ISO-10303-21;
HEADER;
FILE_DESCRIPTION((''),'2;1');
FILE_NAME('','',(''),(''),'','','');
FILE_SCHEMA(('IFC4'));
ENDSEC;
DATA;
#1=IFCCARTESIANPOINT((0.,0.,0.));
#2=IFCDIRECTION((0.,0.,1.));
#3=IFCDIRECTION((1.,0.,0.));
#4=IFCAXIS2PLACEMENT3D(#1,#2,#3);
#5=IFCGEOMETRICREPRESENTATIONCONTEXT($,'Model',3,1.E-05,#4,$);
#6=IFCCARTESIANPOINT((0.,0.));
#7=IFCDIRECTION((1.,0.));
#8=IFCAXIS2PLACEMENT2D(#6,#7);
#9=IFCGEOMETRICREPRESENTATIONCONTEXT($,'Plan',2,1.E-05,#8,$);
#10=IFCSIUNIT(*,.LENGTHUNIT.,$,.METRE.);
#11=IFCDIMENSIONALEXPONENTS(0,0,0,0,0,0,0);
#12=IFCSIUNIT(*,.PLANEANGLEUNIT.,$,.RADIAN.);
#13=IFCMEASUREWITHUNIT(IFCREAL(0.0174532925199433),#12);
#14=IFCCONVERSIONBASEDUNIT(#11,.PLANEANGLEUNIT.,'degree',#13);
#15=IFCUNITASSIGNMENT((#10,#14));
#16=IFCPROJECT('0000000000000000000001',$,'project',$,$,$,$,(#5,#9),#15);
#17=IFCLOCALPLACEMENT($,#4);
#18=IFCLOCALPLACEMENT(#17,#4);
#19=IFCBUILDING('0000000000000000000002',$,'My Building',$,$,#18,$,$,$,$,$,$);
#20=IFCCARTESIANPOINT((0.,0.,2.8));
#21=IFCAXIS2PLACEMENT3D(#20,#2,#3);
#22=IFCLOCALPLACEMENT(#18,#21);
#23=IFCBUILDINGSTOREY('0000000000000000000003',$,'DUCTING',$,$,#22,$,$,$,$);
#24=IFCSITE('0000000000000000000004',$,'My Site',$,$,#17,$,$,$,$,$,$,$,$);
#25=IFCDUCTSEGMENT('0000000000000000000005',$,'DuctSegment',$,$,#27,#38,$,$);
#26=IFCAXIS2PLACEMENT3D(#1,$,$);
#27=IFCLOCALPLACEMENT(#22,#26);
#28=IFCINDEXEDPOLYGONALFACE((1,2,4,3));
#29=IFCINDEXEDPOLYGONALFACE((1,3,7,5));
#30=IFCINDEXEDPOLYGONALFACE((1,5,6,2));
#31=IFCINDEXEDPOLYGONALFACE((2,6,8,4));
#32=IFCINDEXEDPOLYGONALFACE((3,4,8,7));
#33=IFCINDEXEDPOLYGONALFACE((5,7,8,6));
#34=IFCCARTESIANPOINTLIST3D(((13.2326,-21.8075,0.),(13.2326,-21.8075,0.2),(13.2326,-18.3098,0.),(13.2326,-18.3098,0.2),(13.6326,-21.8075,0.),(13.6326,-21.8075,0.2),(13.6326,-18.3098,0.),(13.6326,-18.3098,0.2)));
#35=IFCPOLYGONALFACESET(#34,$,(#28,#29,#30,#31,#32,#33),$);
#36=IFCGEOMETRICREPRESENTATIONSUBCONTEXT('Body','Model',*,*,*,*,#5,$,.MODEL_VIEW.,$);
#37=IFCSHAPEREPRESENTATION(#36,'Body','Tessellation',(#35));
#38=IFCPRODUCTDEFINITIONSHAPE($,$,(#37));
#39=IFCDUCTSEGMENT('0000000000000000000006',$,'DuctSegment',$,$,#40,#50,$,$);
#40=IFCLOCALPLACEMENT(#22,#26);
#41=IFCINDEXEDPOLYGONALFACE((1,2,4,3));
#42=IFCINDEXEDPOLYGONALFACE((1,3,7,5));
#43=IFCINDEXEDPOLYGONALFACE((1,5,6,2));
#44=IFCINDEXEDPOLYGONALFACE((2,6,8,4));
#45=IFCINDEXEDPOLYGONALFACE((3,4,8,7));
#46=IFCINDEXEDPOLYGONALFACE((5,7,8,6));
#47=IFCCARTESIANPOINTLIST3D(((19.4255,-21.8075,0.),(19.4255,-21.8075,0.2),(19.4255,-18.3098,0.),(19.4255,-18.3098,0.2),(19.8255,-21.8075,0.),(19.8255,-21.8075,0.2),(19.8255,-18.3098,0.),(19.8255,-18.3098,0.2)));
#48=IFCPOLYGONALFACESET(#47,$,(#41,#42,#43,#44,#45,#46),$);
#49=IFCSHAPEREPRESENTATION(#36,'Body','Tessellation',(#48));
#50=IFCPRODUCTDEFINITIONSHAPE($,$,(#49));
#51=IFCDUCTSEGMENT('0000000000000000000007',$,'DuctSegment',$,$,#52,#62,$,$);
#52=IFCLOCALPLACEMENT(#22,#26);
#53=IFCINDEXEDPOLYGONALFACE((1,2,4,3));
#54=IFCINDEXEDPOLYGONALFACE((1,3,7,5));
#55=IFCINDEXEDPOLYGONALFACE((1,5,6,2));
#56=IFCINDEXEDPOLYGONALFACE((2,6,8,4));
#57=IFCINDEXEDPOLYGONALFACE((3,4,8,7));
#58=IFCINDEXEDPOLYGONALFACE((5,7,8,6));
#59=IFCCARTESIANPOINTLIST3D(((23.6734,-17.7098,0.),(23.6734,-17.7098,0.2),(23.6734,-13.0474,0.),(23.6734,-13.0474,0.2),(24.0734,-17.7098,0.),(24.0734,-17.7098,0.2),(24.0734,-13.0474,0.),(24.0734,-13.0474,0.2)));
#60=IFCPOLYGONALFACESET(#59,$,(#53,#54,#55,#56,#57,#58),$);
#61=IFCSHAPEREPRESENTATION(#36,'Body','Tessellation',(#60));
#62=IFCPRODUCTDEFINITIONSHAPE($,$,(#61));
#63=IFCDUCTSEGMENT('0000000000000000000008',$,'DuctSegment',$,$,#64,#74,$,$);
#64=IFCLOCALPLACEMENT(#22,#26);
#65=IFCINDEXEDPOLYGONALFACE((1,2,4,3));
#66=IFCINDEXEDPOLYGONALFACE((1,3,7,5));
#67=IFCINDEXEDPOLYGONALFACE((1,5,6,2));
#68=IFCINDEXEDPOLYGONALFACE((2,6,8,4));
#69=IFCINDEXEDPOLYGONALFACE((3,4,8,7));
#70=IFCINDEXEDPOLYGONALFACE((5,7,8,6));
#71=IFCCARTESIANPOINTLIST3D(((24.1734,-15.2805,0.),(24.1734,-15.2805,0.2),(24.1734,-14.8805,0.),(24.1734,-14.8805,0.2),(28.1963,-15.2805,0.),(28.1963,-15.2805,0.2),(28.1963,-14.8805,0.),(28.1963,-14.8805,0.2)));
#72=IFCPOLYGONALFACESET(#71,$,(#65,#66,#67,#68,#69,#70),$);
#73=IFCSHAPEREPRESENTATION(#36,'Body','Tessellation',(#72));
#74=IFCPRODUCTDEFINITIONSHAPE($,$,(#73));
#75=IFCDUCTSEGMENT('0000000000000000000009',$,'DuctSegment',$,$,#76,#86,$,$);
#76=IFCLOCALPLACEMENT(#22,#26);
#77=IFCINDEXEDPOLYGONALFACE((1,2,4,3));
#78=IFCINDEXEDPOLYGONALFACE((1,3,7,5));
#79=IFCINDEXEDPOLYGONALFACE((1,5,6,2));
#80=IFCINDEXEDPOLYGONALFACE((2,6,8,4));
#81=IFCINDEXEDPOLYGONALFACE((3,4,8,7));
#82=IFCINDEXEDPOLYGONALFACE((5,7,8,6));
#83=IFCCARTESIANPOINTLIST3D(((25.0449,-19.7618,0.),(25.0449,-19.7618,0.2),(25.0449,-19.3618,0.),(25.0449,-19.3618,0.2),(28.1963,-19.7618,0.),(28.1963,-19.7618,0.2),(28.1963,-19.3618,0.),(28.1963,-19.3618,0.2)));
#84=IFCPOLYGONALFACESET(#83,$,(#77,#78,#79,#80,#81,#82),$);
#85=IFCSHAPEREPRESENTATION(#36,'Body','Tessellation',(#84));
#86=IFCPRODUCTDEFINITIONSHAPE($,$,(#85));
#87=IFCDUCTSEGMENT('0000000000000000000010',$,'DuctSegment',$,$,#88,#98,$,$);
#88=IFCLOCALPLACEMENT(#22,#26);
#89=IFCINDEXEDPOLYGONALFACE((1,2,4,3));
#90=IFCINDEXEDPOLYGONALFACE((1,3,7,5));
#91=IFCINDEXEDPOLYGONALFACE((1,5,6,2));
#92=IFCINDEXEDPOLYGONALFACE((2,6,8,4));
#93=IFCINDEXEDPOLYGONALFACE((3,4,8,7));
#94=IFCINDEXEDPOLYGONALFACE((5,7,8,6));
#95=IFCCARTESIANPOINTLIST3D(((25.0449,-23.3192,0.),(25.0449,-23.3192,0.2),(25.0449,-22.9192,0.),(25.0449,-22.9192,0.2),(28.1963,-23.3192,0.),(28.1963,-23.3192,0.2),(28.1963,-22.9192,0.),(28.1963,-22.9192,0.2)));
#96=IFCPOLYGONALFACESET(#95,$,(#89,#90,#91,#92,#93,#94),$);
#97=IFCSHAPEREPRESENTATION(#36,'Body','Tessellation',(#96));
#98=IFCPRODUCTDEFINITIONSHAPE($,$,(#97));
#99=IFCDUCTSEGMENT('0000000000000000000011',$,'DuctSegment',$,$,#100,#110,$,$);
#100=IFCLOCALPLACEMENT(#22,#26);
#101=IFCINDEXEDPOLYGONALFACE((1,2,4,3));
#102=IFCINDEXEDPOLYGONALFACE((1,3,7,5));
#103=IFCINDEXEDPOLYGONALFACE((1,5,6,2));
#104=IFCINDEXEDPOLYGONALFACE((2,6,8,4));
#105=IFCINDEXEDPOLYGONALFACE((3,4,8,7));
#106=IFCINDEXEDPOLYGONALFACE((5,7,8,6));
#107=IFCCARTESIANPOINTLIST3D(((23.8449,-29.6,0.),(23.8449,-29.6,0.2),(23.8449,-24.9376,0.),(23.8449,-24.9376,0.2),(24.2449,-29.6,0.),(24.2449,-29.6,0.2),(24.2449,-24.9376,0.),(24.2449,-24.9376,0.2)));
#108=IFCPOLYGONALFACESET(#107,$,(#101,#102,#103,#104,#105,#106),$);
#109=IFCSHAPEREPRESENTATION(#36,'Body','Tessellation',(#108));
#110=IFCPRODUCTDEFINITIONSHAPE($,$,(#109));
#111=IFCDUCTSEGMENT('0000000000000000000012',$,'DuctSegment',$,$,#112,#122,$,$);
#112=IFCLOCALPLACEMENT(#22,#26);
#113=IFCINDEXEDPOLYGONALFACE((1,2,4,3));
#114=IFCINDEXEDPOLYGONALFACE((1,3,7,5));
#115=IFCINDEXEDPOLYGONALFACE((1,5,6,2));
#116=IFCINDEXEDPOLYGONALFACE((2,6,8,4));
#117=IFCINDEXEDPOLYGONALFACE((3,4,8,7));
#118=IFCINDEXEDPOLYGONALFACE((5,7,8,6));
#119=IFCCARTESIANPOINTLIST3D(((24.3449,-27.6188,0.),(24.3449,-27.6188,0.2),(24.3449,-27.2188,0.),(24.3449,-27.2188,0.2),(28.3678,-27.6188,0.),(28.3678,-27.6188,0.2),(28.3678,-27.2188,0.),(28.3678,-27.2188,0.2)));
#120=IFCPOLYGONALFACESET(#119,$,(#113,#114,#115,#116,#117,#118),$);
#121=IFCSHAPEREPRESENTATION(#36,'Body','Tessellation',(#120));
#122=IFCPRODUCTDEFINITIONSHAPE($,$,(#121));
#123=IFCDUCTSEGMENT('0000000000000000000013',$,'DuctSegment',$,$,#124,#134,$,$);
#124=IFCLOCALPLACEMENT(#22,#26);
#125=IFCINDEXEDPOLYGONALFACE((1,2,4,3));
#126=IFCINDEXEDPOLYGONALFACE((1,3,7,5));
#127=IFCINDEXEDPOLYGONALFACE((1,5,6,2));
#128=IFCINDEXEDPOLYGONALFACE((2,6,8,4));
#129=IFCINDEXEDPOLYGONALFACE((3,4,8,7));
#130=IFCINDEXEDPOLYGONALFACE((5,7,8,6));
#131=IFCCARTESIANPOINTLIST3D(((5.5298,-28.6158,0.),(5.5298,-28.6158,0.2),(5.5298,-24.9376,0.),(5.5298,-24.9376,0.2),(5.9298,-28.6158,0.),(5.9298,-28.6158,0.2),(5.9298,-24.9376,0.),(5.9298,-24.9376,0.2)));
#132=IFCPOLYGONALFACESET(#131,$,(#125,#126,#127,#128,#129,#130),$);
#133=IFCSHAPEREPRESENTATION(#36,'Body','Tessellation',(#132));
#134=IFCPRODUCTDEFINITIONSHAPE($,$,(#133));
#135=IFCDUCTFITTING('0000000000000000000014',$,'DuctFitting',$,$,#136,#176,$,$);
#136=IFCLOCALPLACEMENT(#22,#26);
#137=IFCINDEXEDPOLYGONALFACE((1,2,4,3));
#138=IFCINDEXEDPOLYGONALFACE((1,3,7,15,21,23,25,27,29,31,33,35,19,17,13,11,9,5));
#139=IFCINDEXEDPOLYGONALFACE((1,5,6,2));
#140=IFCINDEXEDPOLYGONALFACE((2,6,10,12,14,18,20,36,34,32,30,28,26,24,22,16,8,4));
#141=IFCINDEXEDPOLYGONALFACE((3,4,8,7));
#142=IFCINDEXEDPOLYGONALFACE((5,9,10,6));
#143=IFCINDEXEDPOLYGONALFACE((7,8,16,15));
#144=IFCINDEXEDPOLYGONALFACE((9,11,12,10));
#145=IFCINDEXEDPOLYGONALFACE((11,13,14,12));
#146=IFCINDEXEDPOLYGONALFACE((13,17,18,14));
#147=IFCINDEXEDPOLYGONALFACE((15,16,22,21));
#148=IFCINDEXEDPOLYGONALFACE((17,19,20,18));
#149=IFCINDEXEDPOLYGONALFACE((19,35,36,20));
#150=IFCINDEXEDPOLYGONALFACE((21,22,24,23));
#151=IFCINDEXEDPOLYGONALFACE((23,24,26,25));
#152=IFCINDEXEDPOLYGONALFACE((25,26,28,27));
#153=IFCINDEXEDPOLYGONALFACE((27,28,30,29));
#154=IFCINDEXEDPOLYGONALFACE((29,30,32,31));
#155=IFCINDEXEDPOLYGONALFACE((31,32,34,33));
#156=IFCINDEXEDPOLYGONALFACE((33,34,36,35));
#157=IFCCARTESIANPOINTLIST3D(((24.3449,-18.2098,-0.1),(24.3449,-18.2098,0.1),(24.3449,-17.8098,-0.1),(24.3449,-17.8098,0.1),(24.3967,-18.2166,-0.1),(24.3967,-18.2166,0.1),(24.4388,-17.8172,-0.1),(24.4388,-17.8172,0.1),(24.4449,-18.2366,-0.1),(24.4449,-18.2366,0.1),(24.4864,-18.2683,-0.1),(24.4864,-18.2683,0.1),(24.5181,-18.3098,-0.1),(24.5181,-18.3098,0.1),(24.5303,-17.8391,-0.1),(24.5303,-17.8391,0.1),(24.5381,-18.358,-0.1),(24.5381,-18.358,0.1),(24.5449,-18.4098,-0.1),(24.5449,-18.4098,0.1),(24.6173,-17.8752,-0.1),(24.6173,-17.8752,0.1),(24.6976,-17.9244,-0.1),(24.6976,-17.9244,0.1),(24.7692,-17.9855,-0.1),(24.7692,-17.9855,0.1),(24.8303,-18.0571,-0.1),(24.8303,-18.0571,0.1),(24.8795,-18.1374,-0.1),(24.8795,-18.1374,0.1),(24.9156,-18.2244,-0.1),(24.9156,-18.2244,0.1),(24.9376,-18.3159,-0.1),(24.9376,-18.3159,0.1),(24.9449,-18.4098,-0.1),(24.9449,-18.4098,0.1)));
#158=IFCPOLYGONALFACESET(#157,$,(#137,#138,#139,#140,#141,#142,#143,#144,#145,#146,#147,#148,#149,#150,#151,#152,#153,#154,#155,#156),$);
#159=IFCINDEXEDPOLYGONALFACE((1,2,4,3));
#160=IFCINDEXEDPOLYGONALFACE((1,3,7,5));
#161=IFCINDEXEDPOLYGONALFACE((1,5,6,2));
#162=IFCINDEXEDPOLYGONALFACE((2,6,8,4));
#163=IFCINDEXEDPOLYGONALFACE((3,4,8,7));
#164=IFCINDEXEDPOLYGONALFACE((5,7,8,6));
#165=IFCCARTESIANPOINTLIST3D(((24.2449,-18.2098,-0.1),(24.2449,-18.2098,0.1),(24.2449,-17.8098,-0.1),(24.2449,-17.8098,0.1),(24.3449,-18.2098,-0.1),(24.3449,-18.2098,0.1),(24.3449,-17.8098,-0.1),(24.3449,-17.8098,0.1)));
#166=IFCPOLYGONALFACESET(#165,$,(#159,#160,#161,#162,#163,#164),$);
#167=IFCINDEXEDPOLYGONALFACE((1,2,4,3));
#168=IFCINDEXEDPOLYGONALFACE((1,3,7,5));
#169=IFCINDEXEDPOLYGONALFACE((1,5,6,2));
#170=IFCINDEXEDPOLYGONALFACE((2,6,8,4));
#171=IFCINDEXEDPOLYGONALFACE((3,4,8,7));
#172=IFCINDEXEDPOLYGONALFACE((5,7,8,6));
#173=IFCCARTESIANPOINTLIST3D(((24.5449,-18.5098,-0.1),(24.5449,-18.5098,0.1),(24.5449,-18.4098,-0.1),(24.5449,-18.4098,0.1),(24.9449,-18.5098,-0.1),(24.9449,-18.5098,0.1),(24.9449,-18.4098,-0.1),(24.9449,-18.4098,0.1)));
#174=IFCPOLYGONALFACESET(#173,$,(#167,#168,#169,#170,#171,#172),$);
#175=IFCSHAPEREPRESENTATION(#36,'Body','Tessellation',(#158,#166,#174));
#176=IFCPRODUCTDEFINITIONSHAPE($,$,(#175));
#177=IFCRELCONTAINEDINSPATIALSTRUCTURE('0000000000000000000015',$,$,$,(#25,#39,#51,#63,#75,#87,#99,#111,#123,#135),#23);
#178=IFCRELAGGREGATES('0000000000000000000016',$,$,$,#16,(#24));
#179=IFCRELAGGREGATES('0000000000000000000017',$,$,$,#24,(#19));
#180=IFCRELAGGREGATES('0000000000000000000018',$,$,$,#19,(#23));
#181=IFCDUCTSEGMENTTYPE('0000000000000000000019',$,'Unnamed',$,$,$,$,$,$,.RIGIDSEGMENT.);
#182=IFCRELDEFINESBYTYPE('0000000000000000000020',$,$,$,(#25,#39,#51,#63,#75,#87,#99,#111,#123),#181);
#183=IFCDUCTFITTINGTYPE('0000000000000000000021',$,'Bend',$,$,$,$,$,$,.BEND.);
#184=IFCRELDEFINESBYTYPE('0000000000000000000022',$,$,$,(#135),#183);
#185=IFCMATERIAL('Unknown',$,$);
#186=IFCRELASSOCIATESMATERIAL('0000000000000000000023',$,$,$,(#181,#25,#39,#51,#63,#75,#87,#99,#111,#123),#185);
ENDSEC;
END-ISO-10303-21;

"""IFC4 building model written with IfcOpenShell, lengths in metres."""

from ifc_helpers import new_model, entity, si_unit, converted_unit, frame, origin_with_axes, origin_2d_with_axis, place, context, subcontext, project, spatial, line, arc, indexed_curve, rectangle, outline, extrude, source, transform, mapped, material, material_profile, profile_set, profile_usage, type_object, type_shapes, element, save


model = new_model("IFC4")

# Units and contexts
model_context = context("Model", 3, precision=1e-05, world=origin_with_axes())
plan_context = context("Plan", 2, precision=1e-05, world=origin_2d_with_axis())
body_context = subcontext(model_context, "Body", "Model", "MODEL_VIEW")
ifc_project = project(units=[si_unit("LENGTHUNIT", "METRE"), converted_unit("PLANEANGLEUNIT", "degree", entity("IfcReal", 0.0174532925199433), si_unit("PLANEANGLEUNIT", "RADIAN"), dimensions=[0, 0, 0, 0, 0, 0, 0])], contexts=[model_context, plan_context])

# Site, building, storey
site_placement = place(None, origin_with_axes())
site = spatial("IfcSite", under=ifc_project, at=site_placement, Name="My Site")
building_placement = place(site_placement, origin_with_axes())
building = spatial("IfcBuilding", under=site, at=building_placement, Name="My Building")
storey_placement = place(building_placement, frame((0.0, 0.0, 2.8), z_axis=(0.0, 0.0, 1.0), x_axis=(1.0, 0.0, 0.0)))
storey = spatial("IfcBuildingStorey", under=building, at=storey_placement, Name="DUCTING")

# Duct segments
ifc_material = material(Name="Unknown")
ifc_material_profile_1 = material_profile(ifc_material, rectangle(XDim=0.4, YDim=0.2))
ifc_profile_set_1 = profile_set([ifc_material_profile_1])
duct_segment_type = type_object("IfcDuctSegmentType", Name="Unnamed", PredefinedType="RIGIDSEGMENT", material=ifc_profile_set_1)
ifc_profile_usage_1 = profile_usage(ifc_profile_set_1, cardinal=5)
duct_segment_1_placement = place(storey_placement, frame((13.4326, -18.3098, 0.1), z_axis=(0.0, -1.0, 0.0), x_axis=(1.0, 0.0, 0.0)))
element("IfcDuctSegment", 1, at=duct_segment_1_placement, inside=storey, type_object=duct_segment_type, material=ifc_profile_usage_1, Name="DuctSegment", context=body_context, shape_type="SweptSolid", body=[
    extrude(rectangle(XDim=0.4, YDim=0.2), origin_with_axes(), (0.0, 0.0, 1.0), 3.4977),
])
ifc_profile_usage_2 = profile_usage(ifc_profile_set_1, cardinal=5)
duct_segment_2_placement = place(storey_placement, frame((19.6255, -18.3098, 0.1), z_axis=(0.0, -1.0, 0.0), x_axis=(1.0, 0.0, 0.0)))
element("IfcDuctSegment", 2, at=duct_segment_2_placement, inside=storey, type_object=duct_segment_type, material=ifc_profile_usage_2, Name="DuctSegment", context=body_context, shape_type="SweptSolid", body=[
    extrude(rectangle(XDim=0.4, YDim=0.2), origin_with_axes(), (0.0, 0.0, 1.0), 3.4977),
])
ifc_profile_usage_3 = profile_usage(ifc_profile_set_1, cardinal=5)
duct_segment_3_placement = place(storey_placement, frame((23.8734, -17.7098, 0.1), z_axis=(0.0, 1.0, 0.0), x_axis=(-1.0, 0.0, 0.0)))
element("IfcDuctSegment", 3, at=duct_segment_3_placement, inside=storey, type_object=duct_segment_type, material=ifc_profile_usage_3, Name="DuctSegment", context=body_context, shape_type="SweptSolid", body=[
    extrude(rectangle(XDim=0.4, YDim=0.2), origin_with_axes(), (0.0, 0.0, 1.0), 4.6624),
])
ifc_profile_usage_4 = profile_usage(ifc_profile_set_1, cardinal=5)
duct_segment_4_placement = place(storey_placement, frame((24.1734, -15.0805, 0.1), z_axis=(1.0, 0.0, 0.0), x_axis=(0.0, 1.0, 0.0)))
element("IfcDuctSegment", 4, at=duct_segment_4_placement, inside=storey, type_object=duct_segment_type, material=ifc_profile_usage_4, Name="DuctSegment", context=body_context, shape_type="SweptSolid", body=[
    extrude(rectangle(XDim=0.4, YDim=0.2), origin_with_axes(), (0.0, 0.0, 1.0), 4.0229),
])
ifc_profile_usage_5 = profile_usage(ifc_profile_set_1, cardinal=5)
duct_segment_5_placement = place(storey_placement, frame((25.0449, -19.5618, 0.1), z_axis=(1.0, 0.0, 0.0), x_axis=(0.0, 1.0, 0.0)))
element("IfcDuctSegment", 5, at=duct_segment_5_placement, inside=storey, type_object=duct_segment_type, material=ifc_profile_usage_5, Name="DuctSegment", context=body_context, shape_type="SweptSolid", body=[
    extrude(rectangle(XDim=0.4, YDim=0.2), origin_with_axes(), (0.0, 0.0, 1.0), 3.1514),
])
ifc_profile_usage_6 = profile_usage(ifc_profile_set_1, cardinal=5)
duct_segment_6_placement = place(storey_placement, frame((25.0449, -23.1192, 0.1), z_axis=(1.0, 0.0, 0.0), x_axis=(0.0, 1.0, 0.0)))
element("IfcDuctSegment", 6, at=duct_segment_6_placement, inside=storey, type_object=duct_segment_type, material=ifc_profile_usage_6, Name="DuctSegment", context=body_context, shape_type="SweptSolid", body=[
    extrude(rectangle(XDim=0.4, YDim=0.2), origin_with_axes(), (0.0, 0.0, 1.0), 3.1514),
])
ifc_profile_usage_7 = profile_usage(ifc_profile_set_1, cardinal=5)
duct_segment_7_placement = place(storey_placement, frame((24.0449, -24.9376, 0.1), z_axis=(0.0, -1.0, 0.0), x_axis=(1.0, 0.0, 0.0)))
element("IfcDuctSegment", 7, at=duct_segment_7_placement, inside=storey, type_object=duct_segment_type, material=ifc_profile_usage_7, Name="DuctSegment", context=body_context, shape_type="SweptSolid", body=[
    extrude(rectangle(XDim=0.4, YDim=0.2), origin_with_axes(), (0.0, 0.0, 1.0), 4.6624),
])
ifc_profile_usage_8 = profile_usage(ifc_profile_set_1, cardinal=5)
duct_segment_8_placement = place(storey_placement, frame((24.3449, -27.4188, 0.1), z_axis=(1.0, 0.0, 0.0), x_axis=(0.0, 1.0, 0.0)))
element("IfcDuctSegment", 8, at=duct_segment_8_placement, inside=storey, type_object=duct_segment_type, material=ifc_profile_usage_8, Name="DuctSegment", context=body_context, shape_type="SweptSolid", body=[
    extrude(rectangle(XDim=0.4, YDim=0.2), origin_with_axes(), (0.0, 0.0, 1.0), 4.0229),
])
ifc_profile_usage_9 = profile_usage(ifc_profile_set_1, cardinal=5)
duct_segment_9_placement = place(storey_placement, frame((5.7298, -24.9376, 0.1), z_axis=(0.0, -1.0, 0.0), x_axis=(1.0, 0.0, 0.0)))
element("IfcDuctSegment", 9, at=duct_segment_9_placement, inside=storey, type_object=duct_segment_type, material=ifc_profile_usage_9, Name="DuctSegment", context=body_context, shape_type="SweptSolid", body=[
    extrude(rectangle(XDim=0.4, YDim=0.2), origin_with_axes(), (0.0, 0.0, 1.0), 3.6782),
])

# Duct fitting
duct_fitting_type_1 = type_object("IfcDuctFittingType", Name="Bend", PredefinedType="BEND")
shared_shape = source(origin_with_axes(), body_context, "Body", "SweptSolid", [
    extrude(outline(indexed_curve([(-0.2, 0.0), (-0.2586, -0.1414), (-0.4, -0.2), (-0.4, -0.6), (0.0243, -0.4243), (0.2, 0.0)], segments=[arc(1, 2, 3), line(3, 4), arc(4, 5, 6), line(6, 1)])), frame((0.0, -0.1, -0.1), z_axis=(0.0, -1.0, 0.0), x_axis=(1.0, 0.0, 0.0)), (0.0, 0.0, -1.0), 0.2),
    extrude(rectangle(XDim=0.4, YDim=0.2), origin_with_axes(), (0.0, 0.0, -1.0), 0.1),
    extrude(rectangle(XDim=0.4, YDim=0.2), frame((-0.4, 0.0, -0.5), z_axis=(-1.0, 0.0, 0.0), x_axis=(0.0, 0.0, -1.0)), (0.0, 0.0, 1.0), 0.1),
])
type_shapes(duct_fitting_type_1, [shared_shape])
for number, where, z_axis, x_axis, name in (
    (10, (24.2449, -18.0098, 0.0), (-1.0, 0.0, 0.0), (0.0, 1.0, 0.0), "DuctFitting"),
):
    element("IfcDuctFitting", number, at=place(storey_placement, frame(where, z_axis=z_axis, x_axis=x_axis)), inside=storey, type_object=duct_fitting_type_1, Name=name, context=body_context, shape_type="MappedRepresentation", body=[
        mapped(shared_shape, transform((0.0, 0.0, 0.0), x_axis=(1.0, 0.0, 0.0), y_axis=(0.0, 1.0, 0.0), z_axis=(0.0, 0.0, 1.0), scale=1.0)),
    ])

save(model, "model.ifc")
